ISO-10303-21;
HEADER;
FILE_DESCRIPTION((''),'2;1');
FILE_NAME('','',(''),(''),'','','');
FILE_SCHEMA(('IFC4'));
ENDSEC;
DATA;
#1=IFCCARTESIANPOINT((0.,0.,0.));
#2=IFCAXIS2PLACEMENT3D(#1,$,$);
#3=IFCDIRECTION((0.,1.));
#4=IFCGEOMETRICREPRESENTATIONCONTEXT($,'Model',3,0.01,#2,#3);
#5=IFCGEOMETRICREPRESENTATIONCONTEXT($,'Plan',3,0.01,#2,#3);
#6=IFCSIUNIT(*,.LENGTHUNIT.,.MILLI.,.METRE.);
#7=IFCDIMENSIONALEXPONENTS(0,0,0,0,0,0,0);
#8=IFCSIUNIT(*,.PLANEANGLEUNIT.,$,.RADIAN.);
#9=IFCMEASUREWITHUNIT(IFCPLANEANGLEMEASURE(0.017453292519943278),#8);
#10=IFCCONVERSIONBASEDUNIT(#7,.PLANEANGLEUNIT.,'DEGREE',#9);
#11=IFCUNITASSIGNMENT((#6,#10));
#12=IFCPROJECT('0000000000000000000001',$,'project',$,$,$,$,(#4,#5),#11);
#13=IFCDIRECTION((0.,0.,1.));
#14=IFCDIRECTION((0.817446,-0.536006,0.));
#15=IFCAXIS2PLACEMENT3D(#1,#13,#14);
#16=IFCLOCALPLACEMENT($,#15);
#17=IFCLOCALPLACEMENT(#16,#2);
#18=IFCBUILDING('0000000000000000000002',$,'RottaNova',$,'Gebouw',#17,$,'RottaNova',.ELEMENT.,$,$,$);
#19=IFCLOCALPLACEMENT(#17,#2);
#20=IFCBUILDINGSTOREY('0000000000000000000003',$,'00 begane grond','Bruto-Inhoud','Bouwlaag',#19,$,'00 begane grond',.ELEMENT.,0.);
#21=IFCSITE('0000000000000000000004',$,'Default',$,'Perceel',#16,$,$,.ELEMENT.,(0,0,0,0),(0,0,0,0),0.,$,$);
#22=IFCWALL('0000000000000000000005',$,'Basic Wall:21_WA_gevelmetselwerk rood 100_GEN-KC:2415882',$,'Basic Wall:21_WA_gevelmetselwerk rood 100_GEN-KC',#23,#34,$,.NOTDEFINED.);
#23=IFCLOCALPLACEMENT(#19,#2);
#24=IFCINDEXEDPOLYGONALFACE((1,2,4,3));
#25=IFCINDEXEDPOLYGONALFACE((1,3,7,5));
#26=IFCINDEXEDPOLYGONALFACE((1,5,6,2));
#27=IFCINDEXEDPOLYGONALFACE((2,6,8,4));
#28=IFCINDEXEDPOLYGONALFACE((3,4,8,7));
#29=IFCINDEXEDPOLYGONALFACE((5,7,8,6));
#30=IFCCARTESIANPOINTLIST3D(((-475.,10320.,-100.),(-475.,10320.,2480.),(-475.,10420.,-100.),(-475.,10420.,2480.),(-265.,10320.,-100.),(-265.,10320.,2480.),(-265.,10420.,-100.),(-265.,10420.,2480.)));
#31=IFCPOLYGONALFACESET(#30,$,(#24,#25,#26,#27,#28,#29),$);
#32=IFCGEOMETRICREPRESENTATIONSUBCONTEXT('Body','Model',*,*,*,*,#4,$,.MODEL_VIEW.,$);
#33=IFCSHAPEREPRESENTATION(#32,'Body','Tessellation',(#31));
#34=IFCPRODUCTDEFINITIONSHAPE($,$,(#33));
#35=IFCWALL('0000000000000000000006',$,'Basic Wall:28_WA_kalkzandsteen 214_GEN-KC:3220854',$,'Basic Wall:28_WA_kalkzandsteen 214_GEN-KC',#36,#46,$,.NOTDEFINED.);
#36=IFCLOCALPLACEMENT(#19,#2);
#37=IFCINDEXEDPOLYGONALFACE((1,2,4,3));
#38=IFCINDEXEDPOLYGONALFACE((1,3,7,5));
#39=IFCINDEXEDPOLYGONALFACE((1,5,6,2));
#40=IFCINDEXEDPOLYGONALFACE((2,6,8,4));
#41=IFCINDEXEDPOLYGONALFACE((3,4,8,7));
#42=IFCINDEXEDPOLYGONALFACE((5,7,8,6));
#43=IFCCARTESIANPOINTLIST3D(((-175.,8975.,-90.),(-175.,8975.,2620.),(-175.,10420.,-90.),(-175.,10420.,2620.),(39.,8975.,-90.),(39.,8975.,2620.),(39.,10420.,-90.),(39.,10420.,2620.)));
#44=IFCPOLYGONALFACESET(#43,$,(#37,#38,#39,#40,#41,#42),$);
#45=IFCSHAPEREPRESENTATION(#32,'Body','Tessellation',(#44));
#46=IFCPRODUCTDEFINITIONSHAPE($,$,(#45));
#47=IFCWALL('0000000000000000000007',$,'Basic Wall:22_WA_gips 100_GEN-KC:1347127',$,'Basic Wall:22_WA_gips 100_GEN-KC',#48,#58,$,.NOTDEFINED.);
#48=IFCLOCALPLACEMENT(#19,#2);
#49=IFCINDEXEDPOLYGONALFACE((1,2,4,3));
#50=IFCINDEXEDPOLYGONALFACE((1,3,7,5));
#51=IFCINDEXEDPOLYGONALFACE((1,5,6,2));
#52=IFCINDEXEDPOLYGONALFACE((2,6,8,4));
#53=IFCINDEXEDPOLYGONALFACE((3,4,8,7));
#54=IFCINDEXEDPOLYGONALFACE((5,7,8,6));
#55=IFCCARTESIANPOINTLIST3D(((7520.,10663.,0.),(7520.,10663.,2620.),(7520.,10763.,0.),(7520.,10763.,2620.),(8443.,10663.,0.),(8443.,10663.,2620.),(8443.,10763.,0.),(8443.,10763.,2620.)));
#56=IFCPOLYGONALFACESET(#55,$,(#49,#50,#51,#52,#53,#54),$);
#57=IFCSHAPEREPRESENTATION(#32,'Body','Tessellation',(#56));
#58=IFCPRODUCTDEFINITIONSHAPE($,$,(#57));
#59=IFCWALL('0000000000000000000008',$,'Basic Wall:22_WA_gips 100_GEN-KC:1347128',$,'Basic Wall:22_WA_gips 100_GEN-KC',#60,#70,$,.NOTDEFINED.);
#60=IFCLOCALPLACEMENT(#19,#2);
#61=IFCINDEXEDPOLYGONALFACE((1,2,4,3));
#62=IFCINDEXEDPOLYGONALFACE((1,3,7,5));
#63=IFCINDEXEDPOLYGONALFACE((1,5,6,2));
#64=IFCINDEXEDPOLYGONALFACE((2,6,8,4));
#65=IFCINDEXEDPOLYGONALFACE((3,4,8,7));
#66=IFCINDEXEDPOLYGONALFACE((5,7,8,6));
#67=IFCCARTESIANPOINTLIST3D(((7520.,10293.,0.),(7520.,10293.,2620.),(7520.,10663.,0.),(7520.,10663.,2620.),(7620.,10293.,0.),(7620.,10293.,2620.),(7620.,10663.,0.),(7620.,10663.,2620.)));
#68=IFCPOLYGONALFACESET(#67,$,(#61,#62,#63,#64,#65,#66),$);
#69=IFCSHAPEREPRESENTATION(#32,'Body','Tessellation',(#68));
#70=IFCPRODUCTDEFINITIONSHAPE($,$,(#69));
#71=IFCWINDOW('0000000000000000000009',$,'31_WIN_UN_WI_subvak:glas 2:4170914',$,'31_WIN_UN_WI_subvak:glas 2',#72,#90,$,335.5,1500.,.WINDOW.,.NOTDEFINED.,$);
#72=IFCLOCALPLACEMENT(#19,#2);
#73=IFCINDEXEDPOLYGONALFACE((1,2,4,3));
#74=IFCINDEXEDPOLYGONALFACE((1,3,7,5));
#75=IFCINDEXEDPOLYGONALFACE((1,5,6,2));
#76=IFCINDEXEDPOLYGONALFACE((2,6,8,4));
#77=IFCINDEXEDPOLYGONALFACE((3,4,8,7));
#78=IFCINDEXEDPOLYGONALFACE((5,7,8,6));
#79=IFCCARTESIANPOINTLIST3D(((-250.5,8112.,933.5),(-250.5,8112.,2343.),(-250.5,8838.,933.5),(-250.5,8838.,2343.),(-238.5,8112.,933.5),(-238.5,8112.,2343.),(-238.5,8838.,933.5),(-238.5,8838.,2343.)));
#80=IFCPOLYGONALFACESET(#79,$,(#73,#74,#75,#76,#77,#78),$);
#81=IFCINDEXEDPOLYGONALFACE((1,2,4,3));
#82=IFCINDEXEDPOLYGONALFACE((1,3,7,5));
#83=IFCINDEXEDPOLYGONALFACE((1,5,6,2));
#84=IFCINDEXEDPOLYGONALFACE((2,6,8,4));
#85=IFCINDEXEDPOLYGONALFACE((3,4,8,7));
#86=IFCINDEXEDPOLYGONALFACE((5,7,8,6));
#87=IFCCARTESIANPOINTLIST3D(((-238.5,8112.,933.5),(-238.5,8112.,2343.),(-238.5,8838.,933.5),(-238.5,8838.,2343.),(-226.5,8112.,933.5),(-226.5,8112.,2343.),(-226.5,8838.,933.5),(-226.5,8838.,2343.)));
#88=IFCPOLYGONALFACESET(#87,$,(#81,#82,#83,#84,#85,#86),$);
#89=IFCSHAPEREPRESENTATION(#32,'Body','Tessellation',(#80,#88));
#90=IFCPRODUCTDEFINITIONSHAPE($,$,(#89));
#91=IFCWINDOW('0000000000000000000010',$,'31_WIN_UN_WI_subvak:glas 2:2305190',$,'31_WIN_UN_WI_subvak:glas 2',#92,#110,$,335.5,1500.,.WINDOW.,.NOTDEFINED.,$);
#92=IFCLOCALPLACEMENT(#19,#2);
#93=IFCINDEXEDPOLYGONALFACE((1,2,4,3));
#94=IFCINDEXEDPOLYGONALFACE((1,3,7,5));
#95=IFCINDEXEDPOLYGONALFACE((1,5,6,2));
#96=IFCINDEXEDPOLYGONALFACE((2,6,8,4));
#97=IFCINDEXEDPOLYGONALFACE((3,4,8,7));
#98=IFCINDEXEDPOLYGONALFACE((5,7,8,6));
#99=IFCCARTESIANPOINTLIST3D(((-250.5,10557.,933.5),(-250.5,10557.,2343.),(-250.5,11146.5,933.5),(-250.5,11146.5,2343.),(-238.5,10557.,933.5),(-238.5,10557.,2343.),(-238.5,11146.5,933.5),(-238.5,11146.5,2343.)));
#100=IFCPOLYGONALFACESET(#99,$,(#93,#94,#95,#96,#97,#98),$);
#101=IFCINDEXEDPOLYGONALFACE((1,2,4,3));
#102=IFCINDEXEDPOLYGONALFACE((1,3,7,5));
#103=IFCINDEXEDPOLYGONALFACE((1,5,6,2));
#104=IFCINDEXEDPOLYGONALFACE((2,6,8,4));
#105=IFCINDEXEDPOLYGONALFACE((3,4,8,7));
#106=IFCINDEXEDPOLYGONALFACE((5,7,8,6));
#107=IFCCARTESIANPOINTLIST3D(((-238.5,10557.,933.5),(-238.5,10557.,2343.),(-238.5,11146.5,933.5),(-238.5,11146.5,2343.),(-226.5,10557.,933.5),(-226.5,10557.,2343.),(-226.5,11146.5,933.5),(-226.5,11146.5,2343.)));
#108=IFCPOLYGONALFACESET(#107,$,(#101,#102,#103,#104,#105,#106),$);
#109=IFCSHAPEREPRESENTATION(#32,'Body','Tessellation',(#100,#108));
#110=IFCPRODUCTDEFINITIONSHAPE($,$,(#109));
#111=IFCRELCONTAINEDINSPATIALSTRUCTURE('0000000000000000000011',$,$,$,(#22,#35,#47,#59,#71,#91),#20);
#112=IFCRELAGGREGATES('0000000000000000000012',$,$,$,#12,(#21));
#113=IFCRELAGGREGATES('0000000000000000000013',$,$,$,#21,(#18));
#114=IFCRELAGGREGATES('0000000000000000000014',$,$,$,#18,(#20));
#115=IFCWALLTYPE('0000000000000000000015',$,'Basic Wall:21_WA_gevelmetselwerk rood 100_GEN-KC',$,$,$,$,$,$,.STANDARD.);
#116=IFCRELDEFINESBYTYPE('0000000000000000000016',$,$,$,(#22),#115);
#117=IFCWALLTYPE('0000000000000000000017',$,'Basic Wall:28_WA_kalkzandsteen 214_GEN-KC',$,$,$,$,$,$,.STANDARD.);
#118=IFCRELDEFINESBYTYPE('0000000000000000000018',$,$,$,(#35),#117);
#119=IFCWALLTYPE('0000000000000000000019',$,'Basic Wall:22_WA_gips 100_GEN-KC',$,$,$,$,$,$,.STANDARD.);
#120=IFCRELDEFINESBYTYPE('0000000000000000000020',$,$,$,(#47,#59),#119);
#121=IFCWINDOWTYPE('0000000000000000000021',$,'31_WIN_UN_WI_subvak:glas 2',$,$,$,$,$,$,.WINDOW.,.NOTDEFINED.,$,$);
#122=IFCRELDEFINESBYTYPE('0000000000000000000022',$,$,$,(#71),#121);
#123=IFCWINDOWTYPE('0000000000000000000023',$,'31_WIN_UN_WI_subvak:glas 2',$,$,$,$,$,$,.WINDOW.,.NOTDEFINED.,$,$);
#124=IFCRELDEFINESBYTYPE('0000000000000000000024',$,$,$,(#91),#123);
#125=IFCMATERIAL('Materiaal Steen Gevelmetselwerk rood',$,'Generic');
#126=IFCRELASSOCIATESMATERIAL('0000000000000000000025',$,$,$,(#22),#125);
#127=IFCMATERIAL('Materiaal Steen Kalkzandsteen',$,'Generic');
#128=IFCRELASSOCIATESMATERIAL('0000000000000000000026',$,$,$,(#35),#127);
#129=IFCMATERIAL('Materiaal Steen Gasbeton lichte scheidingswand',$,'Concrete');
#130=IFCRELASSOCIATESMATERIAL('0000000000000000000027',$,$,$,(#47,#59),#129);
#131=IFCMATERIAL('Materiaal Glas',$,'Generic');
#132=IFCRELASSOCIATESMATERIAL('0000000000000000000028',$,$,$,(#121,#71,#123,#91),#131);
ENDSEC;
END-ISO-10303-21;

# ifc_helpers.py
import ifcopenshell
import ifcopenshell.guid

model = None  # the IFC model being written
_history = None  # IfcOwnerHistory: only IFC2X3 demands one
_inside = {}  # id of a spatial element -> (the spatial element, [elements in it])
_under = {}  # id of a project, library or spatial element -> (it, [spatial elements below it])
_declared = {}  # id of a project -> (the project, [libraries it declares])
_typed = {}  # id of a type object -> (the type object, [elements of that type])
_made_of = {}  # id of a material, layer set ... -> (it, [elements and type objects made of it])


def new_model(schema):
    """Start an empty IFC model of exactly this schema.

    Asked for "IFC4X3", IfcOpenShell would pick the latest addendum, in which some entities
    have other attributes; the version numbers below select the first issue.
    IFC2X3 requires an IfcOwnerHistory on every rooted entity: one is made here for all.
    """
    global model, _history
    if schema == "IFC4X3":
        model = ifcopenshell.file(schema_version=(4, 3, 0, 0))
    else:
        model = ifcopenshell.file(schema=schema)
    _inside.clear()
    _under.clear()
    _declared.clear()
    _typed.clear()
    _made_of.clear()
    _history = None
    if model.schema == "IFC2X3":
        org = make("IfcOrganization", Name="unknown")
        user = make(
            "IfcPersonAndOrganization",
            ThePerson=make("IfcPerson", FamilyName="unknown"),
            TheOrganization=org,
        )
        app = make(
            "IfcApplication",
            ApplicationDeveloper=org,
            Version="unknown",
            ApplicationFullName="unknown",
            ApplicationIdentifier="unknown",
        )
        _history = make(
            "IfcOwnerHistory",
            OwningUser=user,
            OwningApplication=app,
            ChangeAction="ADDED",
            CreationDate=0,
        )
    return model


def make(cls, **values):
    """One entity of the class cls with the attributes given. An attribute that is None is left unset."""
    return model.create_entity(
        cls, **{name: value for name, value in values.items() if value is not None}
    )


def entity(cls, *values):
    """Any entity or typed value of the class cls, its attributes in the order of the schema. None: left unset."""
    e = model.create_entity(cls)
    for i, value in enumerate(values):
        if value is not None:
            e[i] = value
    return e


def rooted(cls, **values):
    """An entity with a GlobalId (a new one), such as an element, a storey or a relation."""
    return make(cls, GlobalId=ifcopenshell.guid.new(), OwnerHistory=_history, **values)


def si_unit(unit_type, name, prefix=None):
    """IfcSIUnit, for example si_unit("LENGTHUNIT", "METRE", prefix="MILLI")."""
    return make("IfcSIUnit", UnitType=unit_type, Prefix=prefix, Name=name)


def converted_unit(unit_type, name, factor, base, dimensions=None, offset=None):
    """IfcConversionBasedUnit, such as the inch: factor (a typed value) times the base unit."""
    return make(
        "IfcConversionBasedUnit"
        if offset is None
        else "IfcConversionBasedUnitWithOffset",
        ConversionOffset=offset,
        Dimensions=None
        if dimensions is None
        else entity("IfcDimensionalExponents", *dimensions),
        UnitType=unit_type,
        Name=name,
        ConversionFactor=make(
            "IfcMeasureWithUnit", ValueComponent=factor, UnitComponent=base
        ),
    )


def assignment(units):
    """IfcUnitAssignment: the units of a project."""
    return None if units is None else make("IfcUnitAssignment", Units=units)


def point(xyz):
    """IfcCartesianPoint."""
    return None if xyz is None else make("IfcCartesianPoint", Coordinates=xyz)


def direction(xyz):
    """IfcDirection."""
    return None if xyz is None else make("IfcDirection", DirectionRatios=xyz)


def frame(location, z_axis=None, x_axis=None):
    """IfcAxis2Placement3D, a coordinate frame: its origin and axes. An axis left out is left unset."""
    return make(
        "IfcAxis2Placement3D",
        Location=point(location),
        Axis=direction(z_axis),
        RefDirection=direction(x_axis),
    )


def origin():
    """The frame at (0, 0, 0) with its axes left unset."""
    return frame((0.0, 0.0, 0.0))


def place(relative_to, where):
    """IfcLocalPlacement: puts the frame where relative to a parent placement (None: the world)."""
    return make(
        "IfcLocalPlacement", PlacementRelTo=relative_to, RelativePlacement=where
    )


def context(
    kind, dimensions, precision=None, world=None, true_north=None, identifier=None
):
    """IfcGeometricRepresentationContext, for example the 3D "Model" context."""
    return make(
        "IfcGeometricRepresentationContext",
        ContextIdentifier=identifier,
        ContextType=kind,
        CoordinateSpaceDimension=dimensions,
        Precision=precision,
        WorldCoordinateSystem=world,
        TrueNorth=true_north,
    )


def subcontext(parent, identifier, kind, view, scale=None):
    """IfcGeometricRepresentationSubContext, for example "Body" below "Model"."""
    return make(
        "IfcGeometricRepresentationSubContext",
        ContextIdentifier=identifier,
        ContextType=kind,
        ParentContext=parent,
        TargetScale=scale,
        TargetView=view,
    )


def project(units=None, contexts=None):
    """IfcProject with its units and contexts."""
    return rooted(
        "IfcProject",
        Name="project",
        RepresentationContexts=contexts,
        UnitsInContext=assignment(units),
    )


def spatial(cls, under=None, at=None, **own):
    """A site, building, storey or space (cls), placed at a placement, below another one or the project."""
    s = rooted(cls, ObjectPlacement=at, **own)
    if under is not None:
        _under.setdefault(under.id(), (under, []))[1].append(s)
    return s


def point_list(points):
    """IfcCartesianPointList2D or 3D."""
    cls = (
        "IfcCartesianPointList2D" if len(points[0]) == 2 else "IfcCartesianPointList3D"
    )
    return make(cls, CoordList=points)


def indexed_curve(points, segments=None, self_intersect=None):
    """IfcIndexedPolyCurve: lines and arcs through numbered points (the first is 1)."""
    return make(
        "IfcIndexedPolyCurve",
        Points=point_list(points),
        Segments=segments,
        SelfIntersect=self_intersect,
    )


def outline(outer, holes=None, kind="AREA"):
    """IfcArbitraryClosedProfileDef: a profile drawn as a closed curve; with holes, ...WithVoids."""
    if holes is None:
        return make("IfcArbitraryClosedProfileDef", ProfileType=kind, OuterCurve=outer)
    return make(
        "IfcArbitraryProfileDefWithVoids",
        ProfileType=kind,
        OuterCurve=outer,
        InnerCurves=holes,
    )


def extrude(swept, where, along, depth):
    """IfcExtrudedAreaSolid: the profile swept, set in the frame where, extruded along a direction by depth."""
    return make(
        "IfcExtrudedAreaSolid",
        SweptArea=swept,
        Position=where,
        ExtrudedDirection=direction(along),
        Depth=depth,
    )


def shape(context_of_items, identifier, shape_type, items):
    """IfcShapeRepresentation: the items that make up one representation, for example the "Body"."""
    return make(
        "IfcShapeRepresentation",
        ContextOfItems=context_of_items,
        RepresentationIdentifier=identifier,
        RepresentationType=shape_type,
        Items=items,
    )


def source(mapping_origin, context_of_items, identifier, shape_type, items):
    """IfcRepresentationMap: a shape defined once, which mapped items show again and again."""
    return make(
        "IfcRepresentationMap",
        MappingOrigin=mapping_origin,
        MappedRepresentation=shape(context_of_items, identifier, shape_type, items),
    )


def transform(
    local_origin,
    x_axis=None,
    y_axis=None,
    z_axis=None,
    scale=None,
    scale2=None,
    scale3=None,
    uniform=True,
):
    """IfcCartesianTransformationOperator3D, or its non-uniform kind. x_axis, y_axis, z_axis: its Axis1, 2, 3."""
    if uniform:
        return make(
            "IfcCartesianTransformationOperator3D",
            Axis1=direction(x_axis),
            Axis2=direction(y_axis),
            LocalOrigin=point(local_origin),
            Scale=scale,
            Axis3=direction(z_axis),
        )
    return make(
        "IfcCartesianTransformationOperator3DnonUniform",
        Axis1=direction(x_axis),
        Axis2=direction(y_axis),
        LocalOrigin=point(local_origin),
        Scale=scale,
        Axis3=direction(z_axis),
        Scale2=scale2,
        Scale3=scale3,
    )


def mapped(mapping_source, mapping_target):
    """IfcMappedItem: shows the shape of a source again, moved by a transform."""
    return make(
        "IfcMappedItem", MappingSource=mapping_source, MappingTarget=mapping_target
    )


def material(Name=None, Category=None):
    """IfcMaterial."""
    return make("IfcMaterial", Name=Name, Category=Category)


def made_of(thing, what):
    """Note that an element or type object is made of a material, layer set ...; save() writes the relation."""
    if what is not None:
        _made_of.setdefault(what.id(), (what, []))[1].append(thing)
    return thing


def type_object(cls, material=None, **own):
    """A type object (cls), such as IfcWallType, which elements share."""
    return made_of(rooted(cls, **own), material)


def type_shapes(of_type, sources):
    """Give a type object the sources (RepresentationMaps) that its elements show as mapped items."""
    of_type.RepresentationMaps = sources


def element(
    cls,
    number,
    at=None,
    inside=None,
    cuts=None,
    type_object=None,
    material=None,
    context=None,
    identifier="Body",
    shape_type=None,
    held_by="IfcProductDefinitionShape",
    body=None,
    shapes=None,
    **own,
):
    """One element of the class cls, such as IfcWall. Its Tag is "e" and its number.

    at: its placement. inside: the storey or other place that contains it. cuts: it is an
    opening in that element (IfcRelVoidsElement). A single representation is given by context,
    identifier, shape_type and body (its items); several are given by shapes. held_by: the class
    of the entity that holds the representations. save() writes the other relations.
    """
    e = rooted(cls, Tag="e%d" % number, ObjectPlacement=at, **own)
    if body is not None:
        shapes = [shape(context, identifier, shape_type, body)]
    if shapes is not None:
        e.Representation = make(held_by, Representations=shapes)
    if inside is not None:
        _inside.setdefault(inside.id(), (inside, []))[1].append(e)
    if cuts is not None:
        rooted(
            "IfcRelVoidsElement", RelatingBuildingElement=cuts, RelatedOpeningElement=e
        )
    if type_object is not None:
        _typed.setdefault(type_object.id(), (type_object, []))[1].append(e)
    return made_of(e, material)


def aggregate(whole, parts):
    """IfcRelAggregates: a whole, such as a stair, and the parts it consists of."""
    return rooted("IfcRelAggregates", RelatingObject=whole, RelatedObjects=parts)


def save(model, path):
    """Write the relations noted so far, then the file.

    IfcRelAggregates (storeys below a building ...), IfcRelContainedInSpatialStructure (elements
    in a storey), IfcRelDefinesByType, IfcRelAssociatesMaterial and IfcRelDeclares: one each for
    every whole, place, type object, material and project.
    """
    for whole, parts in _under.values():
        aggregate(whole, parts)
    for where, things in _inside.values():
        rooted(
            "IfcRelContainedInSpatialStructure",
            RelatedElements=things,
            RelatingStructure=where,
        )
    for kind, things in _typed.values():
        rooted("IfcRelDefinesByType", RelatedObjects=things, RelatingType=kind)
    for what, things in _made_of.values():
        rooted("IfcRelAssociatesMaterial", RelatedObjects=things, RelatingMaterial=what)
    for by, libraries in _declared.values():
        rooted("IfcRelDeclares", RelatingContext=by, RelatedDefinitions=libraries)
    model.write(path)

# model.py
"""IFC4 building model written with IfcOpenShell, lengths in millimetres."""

from ifc_helpers import new_model, entity, si_unit, converted_unit, direction, frame, origin, place, context, subcontext, project, spatial, indexed_curve, outline, extrude, source, transform, mapped, material, type_object, type_shapes, element, save


model = new_model("IFC4")

# Units and contexts
model_context = context("Model", 3, precision=0.01, world=origin(), true_north=direction((0.0, 1.0)))
plan_context = context("Plan", 3, precision=0.01, world=origin(), true_north=direction((0.0, 1.0)))
body_context = subcontext(model_context, "Body", "Model", "MODEL_VIEW")
ifc_project = project(units=[si_unit("LENGTHUNIT", "METRE", prefix="MILLI"), converted_unit("PLANEANGLEUNIT", "DEGREE", entity("IfcPlaneAngleMeasure", 0.017453292519943278), si_unit("PLANEANGLEUNIT", "RADIAN"), dimensions=[0, 0, 0, 0, 0, 0, 0])], contexts=[model_context, plan_context])

# Site, building, storey
site_placement = place(None, frame((0.0, 0.0, 0.0), z_axis=(0.0, 0.0, 1.0), x_axis=(0.817446, -0.536006, 0.0)))
site = spatial("IfcSite", under=ifc_project, at=site_placement, Name="Default", ObjectType="Perceel", CompositionType="ELEMENT", RefLatitude=(0, 0, 0, 0), RefLongitude=(0, 0, 0, 0), RefElevation=0.0)
building_placement = place(site_placement, origin())
building = spatial("IfcBuilding", under=site, at=building_placement, Name="RottaNova", ObjectType="Gebouw", LongName="RottaNova", CompositionType="ELEMENT")
storey_placement = place(building_placement, origin())
storey = spatial("IfcBuildingStorey", under=building, at=storey_placement, Name="00 begane grond", Description="Bruto-Inhoud", ObjectType="Bouwlaag", LongName="00 begane grond", CompositionType="ELEMENT", Elevation=0.0)

# Shared definitions
ifc_material_1 = material(Name="Materiaal Glas", Category="Generic")

# Walls
ifc_material_2 = material(Name="Materiaal Steen Gevelmetselwerk rood", Category="Generic")
wall_type_1 = type_object("IfcWallType", Name="Basic Wall:21_WA_gevelmetselwerk rood 100_GEN-KC", PredefinedType="STANDARD")
wall_1_placement = place(storey_placement, frame((-475.0, 10370.0, -100.0)))
element("IfcWall", 1, at=wall_1_placement, inside=storey, type_object=wall_type_1, material=ifc_material_2, Name="Basic Wall:21_WA_gevelmetselwerk rood 100_GEN-KC:2415882", ObjectType="Basic Wall:21_WA_gevelmetselwerk rood 100_GEN-KC", PredefinedType="NOTDEFINED", context=body_context, shape_type="SweptSolid", body=[
    extrude(outline(indexed_curve([(210.0, 50.0), (0.0, 50.0), (0.0, -50.0), (210.0, -50.0), (210.0, 50.0)], self_intersect=False)), origin(), (0.0, 0.0, 1.0), 2580.0),
])
ifc_material_3 = material(Name="Materiaal Steen Kalkzandsteen", Category="Generic")
wall_type_2 = type_object("IfcWallType", Name="Basic Wall:28_WA_kalkzandsteen 214_GEN-KC", PredefinedType="STANDARD")
wall_2_placement = place(storey_placement, frame((-68.0, 8975.0, -90.0), z_axis=(0.0, 0.0, 1.0), x_axis=(0.0, 1.0, 0.0)))
element("IfcWall", 2, at=wall_2_placement, inside=storey, type_object=wall_type_2, material=ifc_material_3, Name="Basic Wall:28_WA_kalkzandsteen 214_GEN-KC:3220854", ObjectType="Basic Wall:28_WA_kalkzandsteen 214_GEN-KC", PredefinedType="NOTDEFINED", context=body_context, shape_type="SweptSolid", body=[
    extrude(outline(indexed_curve([(1445.0, 107.0), (0.0, 107.0), (0.0, -107.0), (1445.0, -107.0), (1445.0, 107.0)], self_intersect=False)), origin(), (0.0, 0.0, 1.0), 2710.0),
])
ifc_material_4 = material(Name="Materiaal Steen Gasbeton lichte scheidingswand", Category="Concrete")
wall_type_3 = type_object("IfcWallType", Name="Basic Wall:22_WA_gips 100_GEN-KC", PredefinedType="STANDARD")
wall_3_placement = place(storey_placement, frame((7520.0, 10713.0, 0.0)))
element("IfcWall", 3, at=wall_3_placement, inside=storey, type_object=wall_type_3, material=ifc_material_4, Name="Basic Wall:22_WA_gips 100_GEN-KC:1347127", ObjectType="Basic Wall:22_WA_gips 100_GEN-KC", PredefinedType="NOTDEFINED", context=body_context, shape_type="SweptSolid", body=[
    extrude(outline(indexed_curve([(923.0, 50.0), (0.0, 50.0), (0.0, -50.0), (923.0, -50.0), (923.0, 50.0)], self_intersect=False)), origin(), (0.0, 0.0, 1.0), 2620.0),
])
wall_4_placement = place(storey_placement, frame((7570.0, 10663.0, 0.0), z_axis=(0.0, 0.0, 1.0), x_axis=(0.0, -1.0, 0.0)))
element("IfcWall", 4, at=wall_4_placement, inside=storey, type_object=wall_type_3, material=ifc_material_4, Name="Basic Wall:22_WA_gips 100_GEN-KC:1347128", ObjectType="Basic Wall:22_WA_gips 100_GEN-KC", PredefinedType="NOTDEFINED", context=body_context, shape_type="SweptSolid", body=[
    extrude(outline(indexed_curve([(370.0, 50.0), (0.0, 50.0), (0.0, -50.0), (370.0, -50.0), (370.0, 50.0)], self_intersect=False)), origin(), (0.0, 0.0, 1.0), 2620.0),
])

# Windows
window_type_1 = type_object("IfcWindowType", Name="31_WIN_UN_WI_subvak:glas 2", PartitioningType="NOTDEFINED", PredefinedType="WINDOW", material=ifc_material_1)
shared_shape_1 = source(origin(), body_context, "Body", "SweptSolid", [
    extrude(outline(indexed_curve([(-363.0, -6.0), (363.0, -6.0), (363.0, 6.0), (-363.0, 6.0), (-363.0, -6.0)], self_intersect=False)), frame((0.0, -6.0, 0.0)), (0.0, 0.0, 1.0), 1409.5),
    extrude(outline(indexed_curve([(-363.0, -6.0), (363.0, -6.0), (363.0, 6.0), (-363.0, 6.0), (-363.0, -6.0)], self_intersect=False)), frame((0.0, 6.0, 0.0)), (0.0, 0.0, 1.0), 1409.5),
])
type_shapes(window_type_1, [shared_shape_1])
window_1_placement = place(storey_placement, frame((-238.5, 8475.0, 933.5), z_axis=(0.0, 0.0, 1.0), x_axis=(0.0, -1.0, 0.0)))
element("IfcWindow", 5, at=window_1_placement, inside=storey, type_object=window_type_1, material=ifc_material_1, Name="31_WIN_UN_WI_subvak:glas 2:4170914", ObjectType="31_WIN_UN_WI_subvak:glas 2", OverallHeight=335.5, OverallWidth=1500.0, PartitioningType="NOTDEFINED", PredefinedType="WINDOW", context=body_context, shape_type="MappedRepresentation", body=[
    mapped(shared_shape_1, transform((0.0, 0.0, 0.0), scale=1.0)),
])
window_type_2 = type_object("IfcWindowType", Name="31_WIN_UN_WI_subvak:glas 2", PartitioningType="NOTDEFINED", PredefinedType="WINDOW", material=ifc_material_1)
shared_shape_2 = source(origin(), body_context, "Body", "SweptSolid", [
    extrude(outline(indexed_curve([(-6.0, -294.7), (6.0, -294.7), (6.0, 294.7), (-6.0, 294.7), (-6.0, -294.7)], self_intersect=False)), frame((0.0, 6.0, 0.0), z_axis=(0.0, 0.0, 1.0), x_axis=(0.0, -1.0, 0.0)), (0.0, 0.0, 1.0), 1409.5),
    extrude(outline(indexed_curve([(-6.0, -294.8), (6.0, -294.8), (6.0, 294.8), (-6.0, 294.8), (-6.0, -294.8)], self_intersect=False)), frame((0.0, -6.0, 0.0), z_axis=(0.0, 0.0, 1.0), x_axis=(0.0, -1.0, 0.0)), (0.0, 0.0, 1.0), 1409.5),
])
type_shapes(window_type_2, [shared_shape_2])
window_2_placement = place(storey_placement, frame((-238.5, 10851.7, 933.5), z_axis=(0.0, 0.0, 1.0), x_axis=(0.0, 1.0, 0.0)))
element("IfcWindow", 6, at=window_2_placement, inside=storey, type_object=window_type_2, material=ifc_material_1, Name="31_WIN_UN_WI_subvak:glas 2:2305190", ObjectType="31_WIN_UN_WI_subvak:glas 2", OverallHeight=335.5, OverallWidth=1500.0, PartitioningType="NOTDEFINED", PredefinedType="WINDOW", context=body_context, shape_type="MappedRepresentation", body=[
    mapped(shared_shape_2, transform((0.0, 0.0, 0.0), scale=1.0)),
])

save(model, "model.ifc")
